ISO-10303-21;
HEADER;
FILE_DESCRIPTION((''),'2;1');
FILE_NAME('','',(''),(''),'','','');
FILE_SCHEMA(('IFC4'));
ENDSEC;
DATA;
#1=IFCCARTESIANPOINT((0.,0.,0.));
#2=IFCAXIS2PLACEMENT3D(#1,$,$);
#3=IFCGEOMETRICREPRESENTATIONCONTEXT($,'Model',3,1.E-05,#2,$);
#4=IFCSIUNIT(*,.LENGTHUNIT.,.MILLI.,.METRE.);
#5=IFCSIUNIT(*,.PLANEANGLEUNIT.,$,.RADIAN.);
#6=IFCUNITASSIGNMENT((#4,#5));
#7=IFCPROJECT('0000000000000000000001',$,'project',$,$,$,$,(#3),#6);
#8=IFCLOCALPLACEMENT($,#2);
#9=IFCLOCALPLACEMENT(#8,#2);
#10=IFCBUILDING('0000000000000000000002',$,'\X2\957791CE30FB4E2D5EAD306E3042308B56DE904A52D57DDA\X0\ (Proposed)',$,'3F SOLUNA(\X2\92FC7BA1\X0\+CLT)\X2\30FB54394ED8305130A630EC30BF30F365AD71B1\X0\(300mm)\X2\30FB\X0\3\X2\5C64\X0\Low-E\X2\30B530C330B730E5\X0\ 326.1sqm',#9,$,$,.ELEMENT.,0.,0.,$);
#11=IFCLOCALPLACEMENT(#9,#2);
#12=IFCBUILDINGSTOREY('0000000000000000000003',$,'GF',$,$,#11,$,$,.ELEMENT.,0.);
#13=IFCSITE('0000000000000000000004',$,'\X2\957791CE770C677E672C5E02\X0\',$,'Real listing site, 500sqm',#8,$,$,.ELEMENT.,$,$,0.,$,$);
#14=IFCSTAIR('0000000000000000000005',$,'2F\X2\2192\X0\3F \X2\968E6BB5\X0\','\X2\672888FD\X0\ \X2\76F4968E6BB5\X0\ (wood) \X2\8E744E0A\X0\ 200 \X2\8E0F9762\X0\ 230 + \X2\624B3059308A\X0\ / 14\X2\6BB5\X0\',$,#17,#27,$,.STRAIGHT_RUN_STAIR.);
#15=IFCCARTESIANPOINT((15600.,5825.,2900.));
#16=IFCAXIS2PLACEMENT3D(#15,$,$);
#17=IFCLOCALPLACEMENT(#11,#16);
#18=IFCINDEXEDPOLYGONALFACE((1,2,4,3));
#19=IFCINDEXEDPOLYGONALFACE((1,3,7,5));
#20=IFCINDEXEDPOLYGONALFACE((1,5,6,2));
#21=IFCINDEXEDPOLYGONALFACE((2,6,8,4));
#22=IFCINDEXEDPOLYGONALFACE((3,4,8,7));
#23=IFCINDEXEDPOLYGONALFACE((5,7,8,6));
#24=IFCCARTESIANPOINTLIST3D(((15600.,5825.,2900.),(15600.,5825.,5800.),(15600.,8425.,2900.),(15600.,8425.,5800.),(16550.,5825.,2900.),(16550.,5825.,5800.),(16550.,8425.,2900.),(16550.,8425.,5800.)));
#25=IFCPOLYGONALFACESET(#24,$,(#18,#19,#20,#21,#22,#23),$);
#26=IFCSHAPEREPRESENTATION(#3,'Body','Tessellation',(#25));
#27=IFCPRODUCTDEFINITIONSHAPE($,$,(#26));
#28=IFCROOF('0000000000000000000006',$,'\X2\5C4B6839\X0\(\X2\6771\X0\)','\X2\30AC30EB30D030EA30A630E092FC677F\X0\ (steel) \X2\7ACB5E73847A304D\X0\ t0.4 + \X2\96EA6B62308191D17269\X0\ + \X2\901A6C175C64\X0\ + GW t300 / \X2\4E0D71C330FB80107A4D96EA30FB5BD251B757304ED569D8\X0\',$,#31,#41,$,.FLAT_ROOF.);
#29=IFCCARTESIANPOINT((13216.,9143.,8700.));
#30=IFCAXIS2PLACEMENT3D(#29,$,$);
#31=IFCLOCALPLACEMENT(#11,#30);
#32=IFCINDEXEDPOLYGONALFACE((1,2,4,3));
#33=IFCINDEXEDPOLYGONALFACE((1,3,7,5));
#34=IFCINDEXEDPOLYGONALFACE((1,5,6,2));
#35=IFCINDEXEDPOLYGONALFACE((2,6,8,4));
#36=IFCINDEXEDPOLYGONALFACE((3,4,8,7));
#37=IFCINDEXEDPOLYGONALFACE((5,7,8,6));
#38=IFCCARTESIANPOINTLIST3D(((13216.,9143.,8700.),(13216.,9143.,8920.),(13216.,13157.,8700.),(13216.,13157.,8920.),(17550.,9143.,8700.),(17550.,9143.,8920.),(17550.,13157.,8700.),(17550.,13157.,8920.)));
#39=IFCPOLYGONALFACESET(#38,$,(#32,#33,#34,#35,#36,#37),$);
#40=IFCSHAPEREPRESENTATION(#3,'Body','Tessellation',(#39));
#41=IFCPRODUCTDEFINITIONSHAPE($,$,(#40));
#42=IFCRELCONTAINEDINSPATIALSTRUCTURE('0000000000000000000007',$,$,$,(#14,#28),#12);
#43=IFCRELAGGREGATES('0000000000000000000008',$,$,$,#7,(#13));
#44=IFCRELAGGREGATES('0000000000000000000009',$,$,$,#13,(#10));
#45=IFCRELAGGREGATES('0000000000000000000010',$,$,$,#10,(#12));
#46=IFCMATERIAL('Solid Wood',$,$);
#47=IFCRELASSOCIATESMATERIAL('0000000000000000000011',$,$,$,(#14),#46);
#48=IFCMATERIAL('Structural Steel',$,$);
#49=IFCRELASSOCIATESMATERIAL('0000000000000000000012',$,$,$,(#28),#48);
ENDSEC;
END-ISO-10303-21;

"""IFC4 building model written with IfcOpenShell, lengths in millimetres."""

from ifc_helpers import new_model, si_unit, frame, frame_2d, origin, place, context, project, spatial, rectangle, extrude, material, element, save


model = new_model("IFC4")

# Units and contexts
model_context = context("Model", 3, precision=1e-05, world=origin())
ifc_project = project(units=[si_unit("LENGTHUNIT", "METRE", prefix="MILLI"), si_unit("PLANEANGLEUNIT", "RADIAN")], contexts=[model_context])

# Site, building, storey
site_placement = place(None, origin())
site = spatial("IfcSite", under=ifc_project, at=site_placement, Name="長野県松本市", ObjectType="Real listing site, 500sqm", CompositionType="ELEMENT", RefElevation=0.0)
building_placement = place(site_placement, origin())
building = spatial("IfcBuilding", under=site, at=building_placement, Name="長野・中庭のある回遊動線 (Proposed)", ObjectType="3F SOLUNA(鋼管+CLT)・吹付けウレタン断熱(300mm)・3層Low-Eサッシュ 326.1sqm", CompositionType="ELEMENT", ElevationOfRefHeight=0.0, ElevationOfTerrain=0.0)
storey_placement = place(building_placement, origin())
storey = spatial("IfcBuildingStorey", under=building, at=storey_placement, Name="GF", CompositionType="ELEMENT", Elevation=0.0)

# Shared definitions
ifc_material_1 = material(Name="Solid Wood")

# Stair
stair_placement = place(storey_placement, frame((15600.0, 5825.0, 2900.0)))
element("IfcStair", 1, at=stair_placement, inside=storey, material=ifc_material_1, Name="2F→3F 階段", Description="木製 直階段 (wood) 蹴上 200 踏面 230 + 手すり / 14段", PredefinedType="STRAIGHT_RUN_STAIR", context=model_context, shape_type="SweptSolid", body=[
    extrude(rectangle(XDim=950.0, YDim=2600.0, at=frame_2d((475.0, 1300.0))), frame((15600.0, 5825.0, 2900.0)), (0.0, 0.0, 1.0), 2900.0),
])

# Roof
ifc_material_2 = material(Name="Structural Steel")
roof_placement = place(storey_placement, frame((13216.0, 9143.0, 8700.0)))
element("IfcRoof", 2, at=roof_placement, inside=storey, material=ifc_material_2, Name="屋根(東)", Description="ガルバリウム鋼板 (steel) 立平葺き t0.4 + 雪止め金物 + 通気層 + GW t300 / 不燃・耐積雪・寒冷地仕様", PredefinedType="FLAT_ROOF", context=model_context, shape_type="SweptSolid", body=[
    extrude(rectangle(XDim=4334.0, YDim=4014.0, at=frame_2d((2167.0, 2007.0))), frame((13216.0, 9143.0, 8700.0)), (0.0, 0.0, 1.0), 220.0),
])

save(model, "model.ifc")
